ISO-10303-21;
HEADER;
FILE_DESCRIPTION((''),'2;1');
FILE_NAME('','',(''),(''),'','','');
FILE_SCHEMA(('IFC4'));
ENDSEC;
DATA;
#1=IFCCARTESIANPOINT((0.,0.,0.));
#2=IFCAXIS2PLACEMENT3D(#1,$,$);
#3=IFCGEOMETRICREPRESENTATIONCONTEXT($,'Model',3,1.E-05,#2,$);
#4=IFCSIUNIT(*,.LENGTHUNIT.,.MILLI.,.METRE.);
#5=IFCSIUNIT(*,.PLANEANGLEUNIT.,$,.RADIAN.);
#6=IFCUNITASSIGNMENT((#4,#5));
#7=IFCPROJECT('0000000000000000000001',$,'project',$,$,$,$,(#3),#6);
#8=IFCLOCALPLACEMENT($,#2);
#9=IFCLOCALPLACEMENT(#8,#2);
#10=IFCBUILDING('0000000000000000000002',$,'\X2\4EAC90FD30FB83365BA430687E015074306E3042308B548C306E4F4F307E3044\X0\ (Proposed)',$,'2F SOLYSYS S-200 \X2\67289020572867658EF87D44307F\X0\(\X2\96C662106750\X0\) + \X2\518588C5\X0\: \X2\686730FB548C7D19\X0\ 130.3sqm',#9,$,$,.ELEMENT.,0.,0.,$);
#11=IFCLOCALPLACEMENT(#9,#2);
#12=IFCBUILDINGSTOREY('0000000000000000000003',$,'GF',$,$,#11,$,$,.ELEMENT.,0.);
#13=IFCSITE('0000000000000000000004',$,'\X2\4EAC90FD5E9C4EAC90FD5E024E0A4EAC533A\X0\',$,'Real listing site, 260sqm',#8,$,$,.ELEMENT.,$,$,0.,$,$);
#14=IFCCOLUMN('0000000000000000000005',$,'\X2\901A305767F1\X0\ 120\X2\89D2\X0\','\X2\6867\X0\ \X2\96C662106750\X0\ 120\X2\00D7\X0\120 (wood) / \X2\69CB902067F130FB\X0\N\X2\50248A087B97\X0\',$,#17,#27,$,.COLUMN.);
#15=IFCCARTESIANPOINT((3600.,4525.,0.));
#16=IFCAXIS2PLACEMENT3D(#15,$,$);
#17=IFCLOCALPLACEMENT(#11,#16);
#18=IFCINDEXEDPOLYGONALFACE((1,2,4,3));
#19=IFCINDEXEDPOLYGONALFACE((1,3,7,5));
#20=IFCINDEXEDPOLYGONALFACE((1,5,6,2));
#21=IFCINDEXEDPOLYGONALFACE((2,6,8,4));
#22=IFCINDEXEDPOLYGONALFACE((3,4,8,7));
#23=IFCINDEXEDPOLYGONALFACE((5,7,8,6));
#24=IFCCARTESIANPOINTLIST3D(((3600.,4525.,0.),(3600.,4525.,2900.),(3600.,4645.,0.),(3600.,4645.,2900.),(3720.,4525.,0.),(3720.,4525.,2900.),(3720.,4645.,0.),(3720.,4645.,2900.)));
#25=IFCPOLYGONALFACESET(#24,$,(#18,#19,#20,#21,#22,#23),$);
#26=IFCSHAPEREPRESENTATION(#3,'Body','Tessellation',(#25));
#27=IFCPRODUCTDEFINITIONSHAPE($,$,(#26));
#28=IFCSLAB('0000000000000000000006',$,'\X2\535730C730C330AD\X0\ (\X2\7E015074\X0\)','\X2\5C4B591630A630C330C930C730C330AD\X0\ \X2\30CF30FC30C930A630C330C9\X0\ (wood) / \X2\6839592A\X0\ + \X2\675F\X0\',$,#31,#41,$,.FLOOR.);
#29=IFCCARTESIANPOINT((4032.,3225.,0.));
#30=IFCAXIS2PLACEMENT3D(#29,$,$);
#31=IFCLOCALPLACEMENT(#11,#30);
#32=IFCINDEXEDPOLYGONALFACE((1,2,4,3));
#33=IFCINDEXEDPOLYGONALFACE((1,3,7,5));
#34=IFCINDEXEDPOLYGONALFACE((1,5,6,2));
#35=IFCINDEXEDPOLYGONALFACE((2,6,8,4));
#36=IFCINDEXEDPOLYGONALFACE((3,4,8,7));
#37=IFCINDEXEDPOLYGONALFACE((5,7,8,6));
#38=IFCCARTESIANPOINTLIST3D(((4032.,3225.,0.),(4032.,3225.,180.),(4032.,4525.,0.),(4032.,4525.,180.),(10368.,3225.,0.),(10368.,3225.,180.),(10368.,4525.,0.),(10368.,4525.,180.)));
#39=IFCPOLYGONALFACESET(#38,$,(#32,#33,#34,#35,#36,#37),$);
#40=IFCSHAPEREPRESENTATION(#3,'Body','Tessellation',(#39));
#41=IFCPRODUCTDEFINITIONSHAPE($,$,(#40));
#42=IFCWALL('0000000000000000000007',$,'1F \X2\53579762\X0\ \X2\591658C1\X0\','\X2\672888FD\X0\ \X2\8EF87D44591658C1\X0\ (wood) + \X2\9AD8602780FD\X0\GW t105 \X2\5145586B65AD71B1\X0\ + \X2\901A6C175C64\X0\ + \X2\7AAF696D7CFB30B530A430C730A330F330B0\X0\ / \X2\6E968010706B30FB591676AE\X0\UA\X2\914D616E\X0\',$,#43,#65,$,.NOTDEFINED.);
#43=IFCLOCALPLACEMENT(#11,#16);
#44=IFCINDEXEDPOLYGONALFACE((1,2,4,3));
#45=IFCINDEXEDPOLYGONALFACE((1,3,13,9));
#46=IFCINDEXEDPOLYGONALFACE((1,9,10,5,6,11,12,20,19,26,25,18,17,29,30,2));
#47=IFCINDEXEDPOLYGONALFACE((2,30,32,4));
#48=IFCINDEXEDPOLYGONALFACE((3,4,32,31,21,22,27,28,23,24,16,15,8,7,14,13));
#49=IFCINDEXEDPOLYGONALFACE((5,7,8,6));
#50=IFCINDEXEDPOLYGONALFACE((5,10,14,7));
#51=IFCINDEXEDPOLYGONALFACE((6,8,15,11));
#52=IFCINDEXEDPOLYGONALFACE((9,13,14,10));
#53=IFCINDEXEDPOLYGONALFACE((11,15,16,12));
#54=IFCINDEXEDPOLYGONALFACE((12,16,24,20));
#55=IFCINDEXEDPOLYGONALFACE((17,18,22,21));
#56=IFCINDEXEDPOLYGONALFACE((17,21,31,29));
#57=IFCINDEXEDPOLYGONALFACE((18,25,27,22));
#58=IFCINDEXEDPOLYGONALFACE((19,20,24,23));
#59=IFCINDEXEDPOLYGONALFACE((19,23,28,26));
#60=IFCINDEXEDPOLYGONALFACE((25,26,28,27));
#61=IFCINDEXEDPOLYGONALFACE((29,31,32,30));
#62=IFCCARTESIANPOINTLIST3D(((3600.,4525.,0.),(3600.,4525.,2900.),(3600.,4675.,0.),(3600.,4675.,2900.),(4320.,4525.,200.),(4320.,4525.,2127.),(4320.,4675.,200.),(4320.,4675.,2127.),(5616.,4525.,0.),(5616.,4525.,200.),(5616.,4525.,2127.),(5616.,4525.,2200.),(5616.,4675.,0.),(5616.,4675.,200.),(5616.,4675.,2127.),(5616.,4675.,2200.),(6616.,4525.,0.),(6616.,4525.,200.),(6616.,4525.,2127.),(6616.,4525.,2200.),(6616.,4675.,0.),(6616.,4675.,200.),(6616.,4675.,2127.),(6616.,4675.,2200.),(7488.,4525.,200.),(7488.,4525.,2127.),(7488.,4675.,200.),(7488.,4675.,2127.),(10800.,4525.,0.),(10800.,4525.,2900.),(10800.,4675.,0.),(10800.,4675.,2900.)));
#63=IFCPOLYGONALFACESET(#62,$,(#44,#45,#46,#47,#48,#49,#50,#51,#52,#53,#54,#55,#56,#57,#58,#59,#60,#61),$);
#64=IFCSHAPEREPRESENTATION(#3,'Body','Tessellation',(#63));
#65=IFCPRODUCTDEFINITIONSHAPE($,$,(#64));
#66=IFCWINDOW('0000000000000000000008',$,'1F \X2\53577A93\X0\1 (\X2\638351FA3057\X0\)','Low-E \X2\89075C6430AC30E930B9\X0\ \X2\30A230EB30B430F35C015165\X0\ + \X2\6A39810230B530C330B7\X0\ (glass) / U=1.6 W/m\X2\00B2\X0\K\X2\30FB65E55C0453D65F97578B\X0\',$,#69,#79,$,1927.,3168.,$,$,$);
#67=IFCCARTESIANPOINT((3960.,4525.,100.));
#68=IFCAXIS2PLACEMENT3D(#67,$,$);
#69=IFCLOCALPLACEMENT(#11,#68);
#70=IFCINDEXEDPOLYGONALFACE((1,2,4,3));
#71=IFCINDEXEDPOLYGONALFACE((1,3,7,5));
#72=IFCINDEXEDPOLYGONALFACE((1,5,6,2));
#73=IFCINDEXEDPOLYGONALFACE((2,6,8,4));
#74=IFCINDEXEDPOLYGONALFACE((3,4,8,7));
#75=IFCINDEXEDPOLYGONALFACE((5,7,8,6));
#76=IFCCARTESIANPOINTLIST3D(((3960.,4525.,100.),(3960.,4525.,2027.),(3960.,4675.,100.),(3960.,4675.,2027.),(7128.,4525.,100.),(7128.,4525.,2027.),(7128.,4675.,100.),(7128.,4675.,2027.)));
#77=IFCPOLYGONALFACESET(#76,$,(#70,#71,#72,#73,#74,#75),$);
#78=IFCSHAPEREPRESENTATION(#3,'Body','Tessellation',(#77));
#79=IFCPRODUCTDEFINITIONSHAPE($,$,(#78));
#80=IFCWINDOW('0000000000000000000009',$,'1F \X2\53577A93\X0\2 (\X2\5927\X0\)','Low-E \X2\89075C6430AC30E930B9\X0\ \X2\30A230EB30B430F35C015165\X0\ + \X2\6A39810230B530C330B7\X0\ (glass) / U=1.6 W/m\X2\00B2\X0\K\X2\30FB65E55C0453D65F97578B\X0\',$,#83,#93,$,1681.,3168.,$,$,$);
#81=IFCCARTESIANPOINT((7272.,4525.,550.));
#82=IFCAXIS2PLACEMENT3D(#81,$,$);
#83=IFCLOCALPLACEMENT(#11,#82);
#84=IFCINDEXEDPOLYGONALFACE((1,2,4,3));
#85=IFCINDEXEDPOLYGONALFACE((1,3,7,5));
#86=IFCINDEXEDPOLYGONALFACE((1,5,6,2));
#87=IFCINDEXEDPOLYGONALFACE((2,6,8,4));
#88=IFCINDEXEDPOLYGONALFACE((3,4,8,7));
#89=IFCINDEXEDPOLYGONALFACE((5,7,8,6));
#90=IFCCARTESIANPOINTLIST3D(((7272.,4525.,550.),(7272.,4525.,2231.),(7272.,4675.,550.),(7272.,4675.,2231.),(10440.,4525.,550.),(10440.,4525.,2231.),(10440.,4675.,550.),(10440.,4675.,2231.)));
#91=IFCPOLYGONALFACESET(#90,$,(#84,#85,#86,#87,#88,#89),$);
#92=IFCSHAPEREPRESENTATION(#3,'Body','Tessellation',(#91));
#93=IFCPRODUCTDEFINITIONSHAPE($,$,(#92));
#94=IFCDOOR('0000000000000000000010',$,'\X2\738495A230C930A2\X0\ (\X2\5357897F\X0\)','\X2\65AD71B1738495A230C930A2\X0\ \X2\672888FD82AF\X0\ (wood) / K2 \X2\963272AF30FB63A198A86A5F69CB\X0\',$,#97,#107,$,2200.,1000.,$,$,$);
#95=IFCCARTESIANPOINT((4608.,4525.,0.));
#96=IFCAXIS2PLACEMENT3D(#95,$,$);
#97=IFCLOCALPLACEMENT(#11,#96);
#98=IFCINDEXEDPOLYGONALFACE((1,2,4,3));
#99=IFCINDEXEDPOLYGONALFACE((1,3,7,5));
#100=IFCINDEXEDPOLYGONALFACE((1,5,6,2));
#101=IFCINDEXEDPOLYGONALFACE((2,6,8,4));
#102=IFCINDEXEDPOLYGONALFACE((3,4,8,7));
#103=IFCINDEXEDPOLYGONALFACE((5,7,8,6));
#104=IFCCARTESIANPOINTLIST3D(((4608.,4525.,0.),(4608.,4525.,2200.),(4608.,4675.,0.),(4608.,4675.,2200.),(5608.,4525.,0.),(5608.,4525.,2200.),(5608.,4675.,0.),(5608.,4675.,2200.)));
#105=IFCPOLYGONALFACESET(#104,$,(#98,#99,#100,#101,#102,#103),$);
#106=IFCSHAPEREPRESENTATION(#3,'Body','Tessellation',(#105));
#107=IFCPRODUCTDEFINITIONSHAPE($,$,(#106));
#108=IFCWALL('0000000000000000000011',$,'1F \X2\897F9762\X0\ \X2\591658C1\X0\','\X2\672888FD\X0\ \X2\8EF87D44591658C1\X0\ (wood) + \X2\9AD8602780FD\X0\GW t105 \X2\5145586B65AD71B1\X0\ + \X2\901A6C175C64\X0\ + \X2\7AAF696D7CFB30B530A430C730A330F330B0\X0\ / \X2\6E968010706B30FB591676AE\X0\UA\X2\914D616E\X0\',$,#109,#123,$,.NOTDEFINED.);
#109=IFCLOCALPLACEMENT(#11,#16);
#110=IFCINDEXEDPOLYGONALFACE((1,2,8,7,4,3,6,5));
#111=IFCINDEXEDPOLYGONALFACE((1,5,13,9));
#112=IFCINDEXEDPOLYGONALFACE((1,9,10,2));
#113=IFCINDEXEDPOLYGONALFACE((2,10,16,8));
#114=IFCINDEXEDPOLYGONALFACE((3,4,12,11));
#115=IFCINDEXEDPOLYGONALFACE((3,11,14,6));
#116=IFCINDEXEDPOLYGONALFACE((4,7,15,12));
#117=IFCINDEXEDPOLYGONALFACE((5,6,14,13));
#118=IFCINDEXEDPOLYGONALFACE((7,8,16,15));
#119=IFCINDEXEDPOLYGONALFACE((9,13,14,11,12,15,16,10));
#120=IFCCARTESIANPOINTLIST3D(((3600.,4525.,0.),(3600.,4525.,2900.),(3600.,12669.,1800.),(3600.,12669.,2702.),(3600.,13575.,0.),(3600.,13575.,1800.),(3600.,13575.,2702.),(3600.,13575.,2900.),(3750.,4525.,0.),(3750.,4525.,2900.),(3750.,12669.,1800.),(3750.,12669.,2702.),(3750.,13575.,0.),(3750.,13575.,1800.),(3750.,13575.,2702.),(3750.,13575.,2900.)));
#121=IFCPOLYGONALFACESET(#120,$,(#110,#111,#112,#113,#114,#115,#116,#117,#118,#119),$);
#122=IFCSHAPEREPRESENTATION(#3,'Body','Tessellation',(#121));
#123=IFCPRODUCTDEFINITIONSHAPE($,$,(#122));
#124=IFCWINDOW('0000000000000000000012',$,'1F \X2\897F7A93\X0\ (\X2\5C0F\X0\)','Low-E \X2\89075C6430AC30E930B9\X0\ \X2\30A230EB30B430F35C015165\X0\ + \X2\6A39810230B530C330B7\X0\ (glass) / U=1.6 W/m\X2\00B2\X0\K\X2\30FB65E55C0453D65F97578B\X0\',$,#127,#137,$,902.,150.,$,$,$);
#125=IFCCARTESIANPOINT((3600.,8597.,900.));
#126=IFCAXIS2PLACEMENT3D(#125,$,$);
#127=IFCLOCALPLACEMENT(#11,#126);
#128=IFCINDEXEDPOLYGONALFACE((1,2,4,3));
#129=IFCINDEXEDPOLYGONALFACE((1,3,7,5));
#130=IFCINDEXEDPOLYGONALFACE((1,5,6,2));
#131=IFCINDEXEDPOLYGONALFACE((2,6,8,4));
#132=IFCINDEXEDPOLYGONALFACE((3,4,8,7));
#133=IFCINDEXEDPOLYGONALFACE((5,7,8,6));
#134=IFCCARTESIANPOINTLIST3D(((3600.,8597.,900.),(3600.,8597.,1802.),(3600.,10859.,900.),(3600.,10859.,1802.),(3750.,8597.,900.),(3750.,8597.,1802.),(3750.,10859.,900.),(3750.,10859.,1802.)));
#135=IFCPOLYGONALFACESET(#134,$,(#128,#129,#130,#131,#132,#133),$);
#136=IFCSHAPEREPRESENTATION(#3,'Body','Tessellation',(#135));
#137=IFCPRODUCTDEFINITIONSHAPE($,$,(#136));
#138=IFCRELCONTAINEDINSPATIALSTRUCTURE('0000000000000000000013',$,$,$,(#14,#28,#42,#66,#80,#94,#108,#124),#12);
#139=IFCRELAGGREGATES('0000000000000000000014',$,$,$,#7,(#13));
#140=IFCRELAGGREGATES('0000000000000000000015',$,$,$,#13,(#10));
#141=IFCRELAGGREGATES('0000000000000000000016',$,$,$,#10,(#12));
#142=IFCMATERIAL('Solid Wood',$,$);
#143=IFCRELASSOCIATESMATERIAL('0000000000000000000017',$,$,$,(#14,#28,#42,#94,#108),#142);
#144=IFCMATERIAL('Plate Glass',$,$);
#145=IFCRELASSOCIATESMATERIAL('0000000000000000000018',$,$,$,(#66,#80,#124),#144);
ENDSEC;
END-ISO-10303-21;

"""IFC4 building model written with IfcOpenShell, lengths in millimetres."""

from ifc_helpers import new_model, si_unit, frame, frame_2d, origin, place, context, project, spatial, rectangle, extrude, material, element, fill, save


model = new_model("IFC4")

# Units and contexts
model_context = context("Model", 3, precision=1e-05, world=origin())
ifc_project = project(units=[si_unit("LENGTHUNIT", "METRE", prefix="MILLI"), si_unit("PLANEANGLEUNIT", "RADIAN")], contexts=[model_context])

# Site, building, storey
site_placement = place(None, origin())
site = spatial("IfcSite", under=ifc_project, at=site_placement, Name="京都府京都市上京区", ObjectType="Real listing site, 260sqm", CompositionType="ELEMENT", RefElevation=0.0)
building_placement = place(site_placement, origin())
building = spatial("IfcBuilding", under=site, at=building_placement, Name="京都・茶室と縁側のある和の住まい (Proposed)", ObjectType="2F SOLYSYS S-200 木造在来軸組み(集成材) + 内装: 桧・和紙 130.3sqm", CompositionType="ELEMENT", ElevationOfRefHeight=0.0, ElevationOfTerrain=0.0)
storey_placement = place(building_placement, origin())
storey = spatial("IfcBuildingStorey", under=building, at=storey_placement, Name="GF", CompositionType="ELEMENT", Elevation=0.0)

# Column
ifc_material_1 = material(Name="Solid Wood")
column_placement = place(storey_placement, frame((3600.0, 4525.0, 0.0)))
element("IfcColumn", 1, at=column_placement, inside=storey, material=ifc_material_1, Name="通し柱 120角", Description="桧 集成材 120×120 (wood) / 構造柱・N値計算", PredefinedType="COLUMN", context=model_context, shape_type="SweptSolid", body=[
    extrude(rectangle(XDim=120.0, YDim=120.0, at=frame_2d((60.0, 60.0))), frame((3600.0, 4525.0, 0.0)), (0.0, 0.0, 1.0), 2900.0),
])

# Slab
slab_1_placement = place(storey_placement, frame((4032.0, 3225.0, 0.0)))
element("IfcSlab", 2, at=slab_1_placement, inside=storey, material=ifc_material_1, Name="南デッキ (縁側)", Description="屋外ウッドデッキ ハードウッド (wood) / 根太 + 束", PredefinedType="FLOOR", context=model_context, shape_type="SweptSolid", body=[
    extrude(rectangle(XDim=6336.0, YDim=1300.0, at=frame_2d((3168.0, 650.0))), frame((4032.0, 3225.0, 0.0)), (0.0, 0.0, 1.0), 180.0),
])

# Wall, openings, windows, door
wall_1_placement = place(storey_placement, frame((3600.0, 4525.0, 0.0)))
wall_1 = element("IfcWall", 3, at=wall_1_placement, inside=storey, material=ifc_material_1, Name="1F 南面 外壁", Description="木製 軸組外壁 (wood) + 高性能GW t105 充填断熱 + 通気層 + 窯業系サイディング / 準耐火・外皮UA配慮", PredefinedType="NOTDEFINED", context=model_context, shape_type="SweptSolid", body=[
    extrude(rectangle(XDim=7200.0, YDim=150.0, at=frame_2d((3600.0, 75.0))), frame((3600.0, 4525.0, 0.0)), (0.0, 0.0, 1.0), 2900.0),
])
opening_1_placement = place(storey_placement, frame((3960.0, 4525.0, 100.0)))
opening_1 = element("IfcOpeningElement", 4, at=opening_1_placement, cuts=wall_1, PredefinedType="NOTDEFINED", context=model_context, shape_type="SweptSolid", body=[
    extrude(rectangle(XDim=3168.0, YDim=150.0, at=frame_2d((1584.0, 75.0))), frame((3960.0, 4525.0, 100.0)), (0.0, 0.0, 1.0), 1927.0),
])
opening_2_placement = place(storey_placement, frame((7272.0, 4525.0, 550.0)))
opening_2 = element("IfcOpeningElement", 5, at=opening_2_placement, cuts=wall_1, PredefinedType="NOTDEFINED", context=model_context, shape_type="SweptSolid", body=[
    extrude(rectangle(XDim=3168.0, YDim=150.0, at=frame_2d((1584.0, 75.0))), frame((7272.0, 4525.0, 550.0)), (0.0, 0.0, 1.0), 1681.0),
])
opening_3_placement = place(storey_placement, frame((4608.0, 4525.0, 0.0)))
opening_3 = element("IfcOpeningElement", 6, at=opening_3_placement, cuts=wall_1, PredefinedType="NOTDEFINED", context=model_context, shape_type="SweptSolid", body=[
    extrude(rectangle(XDim=1000.0, YDim=150.0, at=frame_2d((500.0, 75.0))), frame((4608.0, 4525.0, 0.0)), (0.0, 0.0, 1.0), 2200.0),
])
ifc_material_2 = material(Name="Plate Glass")
window_1_placement = place(storey_placement, frame((3960.0, 4525.0, 100.0)))
window_1 = element("IfcWindow", 7, at=window_1_placement, inside=storey, material=ifc_material_2, Name="1F 南窓1 (掃出し)", Description="Low-E 複層ガラス アルゴン封入 + 樹脂サッシ (glass) / U=1.6 W/m²K・日射取得型", OverallHeight=1927.0, OverallWidth=3168.0, context=model_context, shape_type="SweptSolid", body=[
    extrude(rectangle(XDim=3168.0, YDim=150.0, at=frame_2d((1584.0, 75.0))), frame((3960.0, 4525.0, 100.0)), (0.0, 0.0, 1.0), 1927.0),
])
fill(opening_1, window_1)
window_2_placement = place(storey_placement, frame((7272.0, 4525.0, 550.0)))
window_2 = element("IfcWindow", 8, at=window_2_placement, inside=storey, material=ifc_material_2, Name="1F 南窓2 (大)", Description="Low-E 複層ガラス アルゴン封入 + 樹脂サッシ (glass) / U=1.6 W/m²K・日射取得型", OverallHeight=1681.0, OverallWidth=3168.0, context=model_context, shape_type="SweptSolid", body=[
    extrude(rectangle(XDim=3168.0, YDim=150.0, at=frame_2d((1584.0, 75.0))), frame((7272.0, 4525.0, 550.0)), (0.0, 0.0, 1.0), 1681.0),
])
fill(opening_2, window_2)
door_placement = place(storey_placement, frame((4608.0, 4525.0, 0.0)))
door = element("IfcDoor", 9, at=door_placement, inside=storey, material=ifc_material_1, Name="玄関ドア (南西)", Description="断熱玄関ドア 木製芯 (wood) / K2 防犯・採風機構", OverallHeight=2200.0, OverallWidth=1000.0, context=model_context, shape_type="SweptSolid", body=[
    extrude(rectangle(XDim=1000.0, YDim=150.0, at=frame_2d((500.0, 75.0))), frame((4608.0, 4525.0, 0.0)), (0.0, 0.0, 1.0), 2200.0),
])
fill(opening_3, door)

# Wall, opening, window
wall_2_placement = place(storey_placement, frame((3600.0, 4525.0, 0.0)))
wall_2 = element("IfcWall", 10, at=wall_2_placement, inside=storey, material=ifc_material_1, Name="1F 西面 外壁", Description="木製 軸組外壁 (wood) + 高性能GW t105 充填断熱 + 通気層 + 窯業系サイディング / 準耐火・外皮UA配慮", PredefinedType="NOTDEFINED", context=model_context, shape_type="SweptSolid", body=[
    extrude(rectangle(XDim=150.0, YDim=9050.0, at=frame_2d((75.0, 4525.0))), frame((3600.0, 4525.0, 0.0)), (0.0, 0.0, 1.0), 2900.0),
])
opening_4_placement = place(storey_placement, frame((3600.0, 8597.0, 900.0)))
opening_4 = element("IfcOpeningElement", 11, at=opening_4_placement, cuts=wall_2, PredefinedType="NOTDEFINED", context=model_context, shape_type="SweptSolid", body=[
    extrude(rectangle(XDim=150.0, YDim=2262.0, at=frame_2d((75.0, 1131.0))), frame((3600.0, 8597.0, 900.0)), (0.0, 0.0, 1.0), 902.0),
])
window_3_placement = place(storey_placement, frame((3600.0, 8597.0, 900.0)))
window_3 = element("IfcWindow", 12, at=window_3_placement, inside=storey, material=ifc_material_2, Name="1F 西窓 (小)", Description="Low-E 複層ガラス アルゴン封入 + 樹脂サッシ (glass) / U=1.6 W/m²K・日射取得型", OverallHeight=902.0, OverallWidth=150.0, context=model_context, shape_type="SweptSolid", body=[
    extrude(rectangle(XDim=150.0, YDim=2262.0, at=frame_2d((75.0, 1131.0))), frame((3600.0, 8597.0, 900.0)), (0.0, 0.0, 1.0), 902.0),
])
fill(opening_4, window_3)

save(model, "model.ifc")
